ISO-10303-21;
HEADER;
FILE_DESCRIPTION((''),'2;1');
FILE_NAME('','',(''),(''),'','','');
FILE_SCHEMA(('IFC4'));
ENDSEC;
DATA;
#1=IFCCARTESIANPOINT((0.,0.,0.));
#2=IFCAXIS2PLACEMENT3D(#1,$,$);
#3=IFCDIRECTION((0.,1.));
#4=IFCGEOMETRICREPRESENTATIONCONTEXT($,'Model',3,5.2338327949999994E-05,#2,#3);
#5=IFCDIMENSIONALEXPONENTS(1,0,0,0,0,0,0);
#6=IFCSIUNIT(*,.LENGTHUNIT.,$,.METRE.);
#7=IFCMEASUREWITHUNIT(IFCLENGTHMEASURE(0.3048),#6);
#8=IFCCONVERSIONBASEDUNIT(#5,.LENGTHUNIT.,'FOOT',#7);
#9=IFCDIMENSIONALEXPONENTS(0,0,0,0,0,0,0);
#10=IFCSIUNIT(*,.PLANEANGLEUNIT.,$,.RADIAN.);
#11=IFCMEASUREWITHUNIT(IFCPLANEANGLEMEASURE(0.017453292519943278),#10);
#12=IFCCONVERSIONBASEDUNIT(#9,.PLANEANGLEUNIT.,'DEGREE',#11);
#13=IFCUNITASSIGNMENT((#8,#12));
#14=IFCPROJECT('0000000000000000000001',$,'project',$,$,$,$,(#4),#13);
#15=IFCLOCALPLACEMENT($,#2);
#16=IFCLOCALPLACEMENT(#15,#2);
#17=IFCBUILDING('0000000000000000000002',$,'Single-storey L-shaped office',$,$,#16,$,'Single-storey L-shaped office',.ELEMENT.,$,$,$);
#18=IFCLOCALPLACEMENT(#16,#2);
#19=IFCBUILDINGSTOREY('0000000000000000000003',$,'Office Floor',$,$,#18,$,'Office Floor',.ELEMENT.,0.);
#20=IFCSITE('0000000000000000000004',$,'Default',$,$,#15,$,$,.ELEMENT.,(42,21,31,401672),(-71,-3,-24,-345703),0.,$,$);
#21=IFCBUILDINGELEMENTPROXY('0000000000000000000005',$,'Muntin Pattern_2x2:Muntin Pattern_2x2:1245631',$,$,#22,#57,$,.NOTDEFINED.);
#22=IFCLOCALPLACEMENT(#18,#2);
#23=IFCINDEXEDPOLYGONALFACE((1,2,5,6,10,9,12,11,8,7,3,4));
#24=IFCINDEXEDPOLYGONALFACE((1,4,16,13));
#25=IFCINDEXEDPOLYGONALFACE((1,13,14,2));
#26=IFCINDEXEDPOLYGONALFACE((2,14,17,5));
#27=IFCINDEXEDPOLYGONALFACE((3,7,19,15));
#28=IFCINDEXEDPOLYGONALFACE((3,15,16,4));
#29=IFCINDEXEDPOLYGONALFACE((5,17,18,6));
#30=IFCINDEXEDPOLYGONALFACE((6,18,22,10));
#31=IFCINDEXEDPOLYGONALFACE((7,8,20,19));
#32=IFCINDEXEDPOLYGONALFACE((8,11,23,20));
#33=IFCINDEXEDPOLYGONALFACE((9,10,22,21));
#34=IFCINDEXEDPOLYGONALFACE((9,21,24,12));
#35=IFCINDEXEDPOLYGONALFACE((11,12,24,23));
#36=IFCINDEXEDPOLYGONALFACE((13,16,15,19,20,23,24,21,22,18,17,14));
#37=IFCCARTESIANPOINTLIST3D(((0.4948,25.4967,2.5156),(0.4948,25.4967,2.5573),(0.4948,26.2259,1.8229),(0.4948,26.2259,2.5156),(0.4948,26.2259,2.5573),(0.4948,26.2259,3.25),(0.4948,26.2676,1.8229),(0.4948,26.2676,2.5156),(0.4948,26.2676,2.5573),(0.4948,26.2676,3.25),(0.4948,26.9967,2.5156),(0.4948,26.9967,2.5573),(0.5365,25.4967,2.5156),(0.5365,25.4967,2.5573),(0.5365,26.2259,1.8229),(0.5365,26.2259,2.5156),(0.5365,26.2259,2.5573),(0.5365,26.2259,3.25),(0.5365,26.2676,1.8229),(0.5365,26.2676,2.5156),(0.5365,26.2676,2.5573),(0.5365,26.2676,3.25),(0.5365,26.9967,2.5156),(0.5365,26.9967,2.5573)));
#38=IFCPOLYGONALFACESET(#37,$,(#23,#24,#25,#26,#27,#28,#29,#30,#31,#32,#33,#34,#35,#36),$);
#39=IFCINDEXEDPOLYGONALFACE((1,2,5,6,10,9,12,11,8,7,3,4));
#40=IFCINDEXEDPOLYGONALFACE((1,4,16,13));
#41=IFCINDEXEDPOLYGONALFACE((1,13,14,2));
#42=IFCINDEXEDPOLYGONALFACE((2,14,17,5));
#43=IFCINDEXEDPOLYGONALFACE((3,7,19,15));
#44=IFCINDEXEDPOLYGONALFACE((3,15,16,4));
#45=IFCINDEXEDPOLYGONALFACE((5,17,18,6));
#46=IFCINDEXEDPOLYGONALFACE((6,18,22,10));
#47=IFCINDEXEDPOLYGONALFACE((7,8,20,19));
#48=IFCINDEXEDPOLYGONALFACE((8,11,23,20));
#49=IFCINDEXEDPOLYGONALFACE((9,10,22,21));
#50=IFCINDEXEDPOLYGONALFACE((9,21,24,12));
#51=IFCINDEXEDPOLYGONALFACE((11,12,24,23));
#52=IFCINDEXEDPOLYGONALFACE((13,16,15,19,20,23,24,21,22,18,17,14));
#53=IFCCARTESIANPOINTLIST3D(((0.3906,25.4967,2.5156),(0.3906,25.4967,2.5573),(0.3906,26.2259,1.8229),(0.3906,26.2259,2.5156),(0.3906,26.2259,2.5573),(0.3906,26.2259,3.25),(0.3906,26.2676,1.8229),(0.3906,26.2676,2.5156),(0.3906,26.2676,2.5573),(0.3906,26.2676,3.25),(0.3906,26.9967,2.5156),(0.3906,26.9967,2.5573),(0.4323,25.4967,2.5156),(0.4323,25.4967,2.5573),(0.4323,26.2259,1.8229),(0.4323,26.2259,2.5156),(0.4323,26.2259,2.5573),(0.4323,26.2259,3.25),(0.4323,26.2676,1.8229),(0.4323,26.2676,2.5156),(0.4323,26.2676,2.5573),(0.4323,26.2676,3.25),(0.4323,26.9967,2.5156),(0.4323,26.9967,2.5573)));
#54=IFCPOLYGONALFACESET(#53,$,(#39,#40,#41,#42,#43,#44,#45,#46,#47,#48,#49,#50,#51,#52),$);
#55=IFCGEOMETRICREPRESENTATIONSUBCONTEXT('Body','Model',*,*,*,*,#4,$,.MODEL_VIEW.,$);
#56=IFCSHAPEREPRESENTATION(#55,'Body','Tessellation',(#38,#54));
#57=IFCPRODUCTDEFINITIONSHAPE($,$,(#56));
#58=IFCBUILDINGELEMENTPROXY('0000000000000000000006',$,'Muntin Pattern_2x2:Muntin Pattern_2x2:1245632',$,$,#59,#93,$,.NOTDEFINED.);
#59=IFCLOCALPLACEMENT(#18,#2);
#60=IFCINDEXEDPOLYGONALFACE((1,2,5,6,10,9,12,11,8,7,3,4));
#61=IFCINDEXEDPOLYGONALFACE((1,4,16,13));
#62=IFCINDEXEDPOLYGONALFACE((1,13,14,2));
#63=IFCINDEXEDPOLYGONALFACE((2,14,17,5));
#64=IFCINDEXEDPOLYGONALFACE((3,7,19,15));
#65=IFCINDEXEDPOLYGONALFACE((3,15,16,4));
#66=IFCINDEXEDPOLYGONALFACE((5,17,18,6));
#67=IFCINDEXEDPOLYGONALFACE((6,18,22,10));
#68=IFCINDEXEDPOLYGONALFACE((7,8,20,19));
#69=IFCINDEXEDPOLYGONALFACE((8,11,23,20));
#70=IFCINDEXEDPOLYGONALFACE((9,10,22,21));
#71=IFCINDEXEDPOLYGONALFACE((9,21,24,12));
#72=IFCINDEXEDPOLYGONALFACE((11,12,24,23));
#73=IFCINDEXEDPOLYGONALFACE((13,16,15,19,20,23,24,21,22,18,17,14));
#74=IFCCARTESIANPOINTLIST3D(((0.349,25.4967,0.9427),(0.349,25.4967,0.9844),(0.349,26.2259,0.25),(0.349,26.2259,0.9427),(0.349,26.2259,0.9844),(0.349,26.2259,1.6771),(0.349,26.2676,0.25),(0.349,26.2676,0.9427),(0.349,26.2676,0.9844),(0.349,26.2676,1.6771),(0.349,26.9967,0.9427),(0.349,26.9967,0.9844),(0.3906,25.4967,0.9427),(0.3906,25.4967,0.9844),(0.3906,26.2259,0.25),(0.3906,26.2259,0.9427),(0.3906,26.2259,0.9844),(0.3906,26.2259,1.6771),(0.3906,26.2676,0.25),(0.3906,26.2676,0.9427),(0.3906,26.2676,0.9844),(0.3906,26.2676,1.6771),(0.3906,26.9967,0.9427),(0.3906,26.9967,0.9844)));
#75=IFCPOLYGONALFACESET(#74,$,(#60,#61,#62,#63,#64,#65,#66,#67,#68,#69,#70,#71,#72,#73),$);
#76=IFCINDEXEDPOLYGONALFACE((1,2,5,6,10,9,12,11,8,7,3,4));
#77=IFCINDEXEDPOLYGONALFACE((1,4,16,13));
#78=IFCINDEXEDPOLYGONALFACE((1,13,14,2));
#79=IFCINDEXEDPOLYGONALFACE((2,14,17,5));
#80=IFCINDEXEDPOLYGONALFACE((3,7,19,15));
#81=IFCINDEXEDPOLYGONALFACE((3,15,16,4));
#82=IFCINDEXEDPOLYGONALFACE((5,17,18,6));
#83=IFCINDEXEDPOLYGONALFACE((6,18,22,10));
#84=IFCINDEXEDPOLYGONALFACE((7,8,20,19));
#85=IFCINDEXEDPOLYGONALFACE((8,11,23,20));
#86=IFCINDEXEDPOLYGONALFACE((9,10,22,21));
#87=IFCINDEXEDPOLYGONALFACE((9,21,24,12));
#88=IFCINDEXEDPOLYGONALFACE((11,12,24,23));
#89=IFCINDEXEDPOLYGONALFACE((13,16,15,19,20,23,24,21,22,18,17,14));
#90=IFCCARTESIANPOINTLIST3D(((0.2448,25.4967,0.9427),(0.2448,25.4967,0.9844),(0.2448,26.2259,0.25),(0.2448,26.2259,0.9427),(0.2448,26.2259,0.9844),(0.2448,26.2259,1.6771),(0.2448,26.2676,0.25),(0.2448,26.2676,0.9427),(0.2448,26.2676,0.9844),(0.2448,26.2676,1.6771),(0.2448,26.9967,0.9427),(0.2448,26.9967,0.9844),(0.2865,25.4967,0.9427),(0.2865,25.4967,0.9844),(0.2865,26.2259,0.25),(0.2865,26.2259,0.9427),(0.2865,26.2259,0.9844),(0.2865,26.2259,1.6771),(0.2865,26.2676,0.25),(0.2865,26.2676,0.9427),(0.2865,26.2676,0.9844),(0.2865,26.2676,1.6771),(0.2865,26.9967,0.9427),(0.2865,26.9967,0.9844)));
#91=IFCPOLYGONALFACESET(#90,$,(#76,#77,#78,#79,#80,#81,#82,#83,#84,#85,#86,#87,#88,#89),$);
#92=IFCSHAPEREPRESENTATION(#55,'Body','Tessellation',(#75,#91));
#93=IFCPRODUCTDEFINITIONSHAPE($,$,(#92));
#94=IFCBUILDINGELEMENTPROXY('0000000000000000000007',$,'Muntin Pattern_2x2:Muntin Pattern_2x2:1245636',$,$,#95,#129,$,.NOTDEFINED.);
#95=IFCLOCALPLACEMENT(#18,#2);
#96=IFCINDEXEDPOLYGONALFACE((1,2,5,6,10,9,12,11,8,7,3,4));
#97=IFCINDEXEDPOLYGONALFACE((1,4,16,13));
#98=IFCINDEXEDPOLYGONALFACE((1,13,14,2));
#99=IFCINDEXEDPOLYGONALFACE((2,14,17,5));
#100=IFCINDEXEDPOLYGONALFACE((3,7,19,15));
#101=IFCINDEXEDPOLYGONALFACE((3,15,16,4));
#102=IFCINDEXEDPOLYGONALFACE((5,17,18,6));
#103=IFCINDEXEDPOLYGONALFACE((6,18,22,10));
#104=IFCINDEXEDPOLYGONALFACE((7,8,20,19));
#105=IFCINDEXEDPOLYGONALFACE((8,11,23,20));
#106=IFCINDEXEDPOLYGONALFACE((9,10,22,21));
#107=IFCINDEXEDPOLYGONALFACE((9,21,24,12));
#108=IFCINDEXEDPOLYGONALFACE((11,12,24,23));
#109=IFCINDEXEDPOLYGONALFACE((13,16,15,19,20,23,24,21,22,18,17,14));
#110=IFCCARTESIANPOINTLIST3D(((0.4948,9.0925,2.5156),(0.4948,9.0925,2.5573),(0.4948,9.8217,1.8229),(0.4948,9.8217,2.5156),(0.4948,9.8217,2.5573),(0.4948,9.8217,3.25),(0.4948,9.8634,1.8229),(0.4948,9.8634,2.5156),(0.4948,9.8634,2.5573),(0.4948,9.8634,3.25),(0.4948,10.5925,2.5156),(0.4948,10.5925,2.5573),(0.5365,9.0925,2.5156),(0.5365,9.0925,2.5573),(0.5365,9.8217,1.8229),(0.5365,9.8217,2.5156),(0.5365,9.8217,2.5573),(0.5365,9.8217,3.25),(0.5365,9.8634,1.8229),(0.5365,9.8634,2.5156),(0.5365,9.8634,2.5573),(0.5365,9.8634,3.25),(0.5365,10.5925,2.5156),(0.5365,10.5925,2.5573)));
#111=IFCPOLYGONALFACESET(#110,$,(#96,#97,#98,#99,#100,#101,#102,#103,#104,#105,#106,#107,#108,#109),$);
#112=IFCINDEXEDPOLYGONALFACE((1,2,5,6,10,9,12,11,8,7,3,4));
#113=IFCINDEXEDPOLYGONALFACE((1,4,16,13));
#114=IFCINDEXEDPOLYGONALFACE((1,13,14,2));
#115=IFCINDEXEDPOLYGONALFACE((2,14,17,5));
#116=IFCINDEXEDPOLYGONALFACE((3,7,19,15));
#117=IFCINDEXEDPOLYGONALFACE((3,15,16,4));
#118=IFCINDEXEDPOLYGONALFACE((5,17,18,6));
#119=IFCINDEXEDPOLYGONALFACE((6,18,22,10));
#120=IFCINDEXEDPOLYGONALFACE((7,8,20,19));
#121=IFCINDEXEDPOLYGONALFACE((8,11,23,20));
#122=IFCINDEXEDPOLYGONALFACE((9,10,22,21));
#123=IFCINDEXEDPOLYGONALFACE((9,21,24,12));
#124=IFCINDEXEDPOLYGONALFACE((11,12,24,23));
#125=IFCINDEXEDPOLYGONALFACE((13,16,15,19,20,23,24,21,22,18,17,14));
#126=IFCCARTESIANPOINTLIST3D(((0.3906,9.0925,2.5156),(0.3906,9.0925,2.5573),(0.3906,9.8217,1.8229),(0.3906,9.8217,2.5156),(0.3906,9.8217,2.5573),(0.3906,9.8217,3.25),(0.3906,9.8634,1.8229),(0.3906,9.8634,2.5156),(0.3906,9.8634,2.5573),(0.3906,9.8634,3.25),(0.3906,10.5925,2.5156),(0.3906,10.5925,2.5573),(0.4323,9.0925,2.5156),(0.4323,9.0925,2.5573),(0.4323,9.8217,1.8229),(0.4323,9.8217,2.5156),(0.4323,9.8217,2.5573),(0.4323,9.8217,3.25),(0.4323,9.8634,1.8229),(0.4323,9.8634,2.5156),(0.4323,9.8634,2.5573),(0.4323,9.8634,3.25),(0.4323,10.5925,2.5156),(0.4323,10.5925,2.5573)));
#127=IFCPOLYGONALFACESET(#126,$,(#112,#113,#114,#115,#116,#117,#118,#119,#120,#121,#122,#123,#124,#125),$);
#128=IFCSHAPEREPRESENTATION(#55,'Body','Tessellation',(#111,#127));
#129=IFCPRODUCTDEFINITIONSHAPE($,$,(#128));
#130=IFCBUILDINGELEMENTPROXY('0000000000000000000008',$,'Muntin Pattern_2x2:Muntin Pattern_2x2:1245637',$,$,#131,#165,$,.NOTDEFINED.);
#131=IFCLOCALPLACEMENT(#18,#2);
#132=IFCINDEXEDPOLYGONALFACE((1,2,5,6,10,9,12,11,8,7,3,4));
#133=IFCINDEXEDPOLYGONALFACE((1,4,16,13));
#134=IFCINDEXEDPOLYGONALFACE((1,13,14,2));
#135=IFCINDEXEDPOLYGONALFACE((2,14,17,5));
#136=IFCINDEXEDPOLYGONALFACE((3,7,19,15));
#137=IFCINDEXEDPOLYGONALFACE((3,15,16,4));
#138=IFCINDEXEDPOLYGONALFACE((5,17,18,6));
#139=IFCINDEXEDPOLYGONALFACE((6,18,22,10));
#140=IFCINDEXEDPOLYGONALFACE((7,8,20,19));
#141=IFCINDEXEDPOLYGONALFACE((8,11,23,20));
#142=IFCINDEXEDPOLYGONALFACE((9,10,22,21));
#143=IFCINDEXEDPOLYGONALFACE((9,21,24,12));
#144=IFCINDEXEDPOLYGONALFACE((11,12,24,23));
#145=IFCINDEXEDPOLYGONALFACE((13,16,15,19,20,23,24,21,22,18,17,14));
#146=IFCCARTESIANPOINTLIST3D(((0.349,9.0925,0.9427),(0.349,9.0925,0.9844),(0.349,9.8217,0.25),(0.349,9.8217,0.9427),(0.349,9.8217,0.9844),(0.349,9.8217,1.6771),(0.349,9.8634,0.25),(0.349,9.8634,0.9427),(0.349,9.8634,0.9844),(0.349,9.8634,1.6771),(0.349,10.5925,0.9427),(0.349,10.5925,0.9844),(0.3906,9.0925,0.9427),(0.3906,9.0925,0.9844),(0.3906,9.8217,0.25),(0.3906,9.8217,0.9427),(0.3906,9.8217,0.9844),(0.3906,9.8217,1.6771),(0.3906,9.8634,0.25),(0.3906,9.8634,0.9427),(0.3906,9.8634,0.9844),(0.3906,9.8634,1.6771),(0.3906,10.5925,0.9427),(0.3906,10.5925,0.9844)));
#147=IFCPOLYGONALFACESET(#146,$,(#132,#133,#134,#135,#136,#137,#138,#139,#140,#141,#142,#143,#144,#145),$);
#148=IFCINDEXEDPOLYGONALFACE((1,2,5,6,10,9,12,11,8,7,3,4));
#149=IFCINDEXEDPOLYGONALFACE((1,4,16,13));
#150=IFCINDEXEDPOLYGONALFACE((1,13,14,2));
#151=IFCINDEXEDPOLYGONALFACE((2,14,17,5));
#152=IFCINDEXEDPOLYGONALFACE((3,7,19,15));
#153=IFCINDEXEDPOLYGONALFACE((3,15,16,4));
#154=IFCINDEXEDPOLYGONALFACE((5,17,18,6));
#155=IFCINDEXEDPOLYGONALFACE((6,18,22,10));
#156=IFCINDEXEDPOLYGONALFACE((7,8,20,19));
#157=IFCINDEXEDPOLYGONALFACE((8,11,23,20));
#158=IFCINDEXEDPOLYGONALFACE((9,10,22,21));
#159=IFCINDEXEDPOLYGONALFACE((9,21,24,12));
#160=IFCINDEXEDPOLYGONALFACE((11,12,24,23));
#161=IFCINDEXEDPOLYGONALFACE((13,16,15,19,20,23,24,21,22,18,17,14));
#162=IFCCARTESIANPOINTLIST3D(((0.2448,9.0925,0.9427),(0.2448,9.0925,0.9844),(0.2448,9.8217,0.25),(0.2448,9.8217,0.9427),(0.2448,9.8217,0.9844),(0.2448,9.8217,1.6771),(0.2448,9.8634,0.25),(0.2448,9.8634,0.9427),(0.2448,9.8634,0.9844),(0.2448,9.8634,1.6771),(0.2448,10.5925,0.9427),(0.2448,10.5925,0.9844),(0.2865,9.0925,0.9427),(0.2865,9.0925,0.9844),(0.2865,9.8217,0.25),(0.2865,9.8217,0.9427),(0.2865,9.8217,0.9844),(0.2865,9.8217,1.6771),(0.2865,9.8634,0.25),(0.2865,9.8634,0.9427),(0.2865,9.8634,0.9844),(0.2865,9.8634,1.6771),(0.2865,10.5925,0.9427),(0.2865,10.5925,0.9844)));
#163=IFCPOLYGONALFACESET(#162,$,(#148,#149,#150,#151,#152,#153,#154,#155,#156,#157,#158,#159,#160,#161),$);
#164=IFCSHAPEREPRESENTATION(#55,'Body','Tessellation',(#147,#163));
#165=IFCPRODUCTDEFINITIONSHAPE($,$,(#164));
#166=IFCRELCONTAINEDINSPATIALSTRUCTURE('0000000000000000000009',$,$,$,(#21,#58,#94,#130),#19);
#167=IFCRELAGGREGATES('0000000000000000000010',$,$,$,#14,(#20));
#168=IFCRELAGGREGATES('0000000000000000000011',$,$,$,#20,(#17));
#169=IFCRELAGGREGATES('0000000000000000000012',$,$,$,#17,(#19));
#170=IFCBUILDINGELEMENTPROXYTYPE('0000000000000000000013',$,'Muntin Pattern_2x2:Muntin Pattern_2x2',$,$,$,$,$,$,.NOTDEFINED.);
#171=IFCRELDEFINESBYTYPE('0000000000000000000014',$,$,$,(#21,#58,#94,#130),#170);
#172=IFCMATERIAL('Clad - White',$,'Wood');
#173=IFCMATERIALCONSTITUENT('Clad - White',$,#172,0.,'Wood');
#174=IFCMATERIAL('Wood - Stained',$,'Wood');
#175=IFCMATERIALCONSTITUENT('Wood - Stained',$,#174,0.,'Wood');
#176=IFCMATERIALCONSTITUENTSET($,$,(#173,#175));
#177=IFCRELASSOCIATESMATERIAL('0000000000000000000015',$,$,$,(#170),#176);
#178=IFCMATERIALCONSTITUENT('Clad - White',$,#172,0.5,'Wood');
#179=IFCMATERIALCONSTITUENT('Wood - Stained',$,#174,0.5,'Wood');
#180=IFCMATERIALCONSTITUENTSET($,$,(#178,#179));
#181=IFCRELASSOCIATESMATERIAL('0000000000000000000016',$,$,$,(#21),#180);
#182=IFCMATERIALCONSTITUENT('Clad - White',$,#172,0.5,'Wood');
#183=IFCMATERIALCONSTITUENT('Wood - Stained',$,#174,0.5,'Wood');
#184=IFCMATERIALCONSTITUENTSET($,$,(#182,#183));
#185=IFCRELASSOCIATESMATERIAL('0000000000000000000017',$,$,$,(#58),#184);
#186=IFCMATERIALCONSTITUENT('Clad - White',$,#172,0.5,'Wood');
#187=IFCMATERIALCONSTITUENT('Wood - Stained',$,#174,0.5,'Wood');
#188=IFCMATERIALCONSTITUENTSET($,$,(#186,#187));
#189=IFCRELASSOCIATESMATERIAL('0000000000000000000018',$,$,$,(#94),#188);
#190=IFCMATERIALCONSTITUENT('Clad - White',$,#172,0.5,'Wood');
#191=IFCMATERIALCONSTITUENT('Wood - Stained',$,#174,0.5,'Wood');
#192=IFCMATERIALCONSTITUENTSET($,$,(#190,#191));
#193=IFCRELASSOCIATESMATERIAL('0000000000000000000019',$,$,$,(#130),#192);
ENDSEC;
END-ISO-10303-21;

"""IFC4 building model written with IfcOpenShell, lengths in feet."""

from ifc_helpers import new_model, entity, si_unit, converted_unit, direction, frame, origin, place, context, subcontext, project, spatial, indexed_curve, outline, extrude, source, transform, mapped, material, constituent, constituent_set, type_object, type_shapes, element, save


model = new_model("IFC4")

# Units and contexts
model_context = context("Model", 3, precision=5.2338327949999994e-05, world=origin(), true_north=direction((0.0, 1.0)))
body_context = subcontext(model_context, "Body", "Model", "MODEL_VIEW")
ifc_project = project(units=[converted_unit("LENGTHUNIT", "FOOT", entity("IfcLengthMeasure", 0.3048), si_unit("LENGTHUNIT", "METRE"), dimensions=[1, 0, 0, 0, 0, 0, 0]), converted_unit("PLANEANGLEUNIT", "DEGREE", entity("IfcPlaneAngleMeasure", 0.017453292519943278), si_unit("PLANEANGLEUNIT", "RADIAN"), dimensions=[0, 0, 0, 0, 0, 0, 0])], contexts=[model_context])

# Site, building, storey
site_placement = place(None, origin())
site = spatial("IfcSite", under=ifc_project, at=site_placement, Name="Default", CompositionType="ELEMENT", RefLatitude=(42, 21, 31, 401672), RefLongitude=(-71, -3, -24, -345703), RefElevation=0.0)
building_placement = place(site_placement, origin())
building = spatial("IfcBuilding", under=site, at=building_placement, Name="Single-storey L-shaped office", LongName="Single-storey L-shaped office", CompositionType="ELEMENT")
storey_placement = place(building_placement, origin())
storey = spatial("IfcBuildingStorey", under=building, at=storey_placement, Name="Office Floor", LongName="Office Floor", CompositionType="ELEMENT", Elevation=0.0)

# Shared definitions
ifc_material_1 = material(Name="Wood - Stained", Category="Wood")

# Building element proxies
ifc_material_2 = material(Name="Clad - White", Category="Wood")
ifc_constituent_1 = constituent(ifc_material_2, Name="Clad - White", Category="Wood", fraction=0.0)
ifc_constituent_2 = constituent(ifc_material_1, Name="Wood - Stained", Category="Wood", fraction=0.0)
ifc_constituent_set_1 = constituent_set(constituents=[ifc_constituent_1, ifc_constituent_2])
building_element_proxy_type_1 = type_object("IfcBuildingElementProxyType", Name="Muntin Pattern_2x2:Muntin Pattern_2x2", PredefinedType="NOTDEFINED", material=ifc_constituent_set_1)
shared_shape_1 = source(origin(), body_context, "Body", "SweptSolid", [
    extrude(outline(indexed_curve([(0.0208, -0.0208), (0.7135, -0.0208), (0.7135, 0.0208), (0.0208, 0.0208), (0.0208, 0.75), (-0.0208, 0.75), (-0.0208, 0.0208), (-0.7135, 0.0208), (-0.7135, -0.0208), (-0.0208, -0.0208), (-0.0208, -0.75), (0.0208, -0.75), (0.0208, -0.0208)], self_intersect=False)), frame((0.0, 0.0312, 0.7135), z_axis=(0.0, 1.0, 0.0), x_axis=(0.0, 0.0, 1.0)), (0.0, 0.0, 1.0), 0.0417),
    extrude(outline(indexed_curve([(0.0208, -0.0208), (0.7135, -0.0208), (0.7135, 0.0208), (0.0208, 0.0208), (0.0208, 0.75), (-0.0208, 0.75), (-0.0208, 0.0208), (-0.7135, 0.0208), (-0.7135, -0.0208), (-0.0208, -0.0208), (-0.0208, -0.75), (0.0208, -0.75), (0.0208, -0.0208)], self_intersect=False)), frame((0.0, -0.0729, 0.7135), z_axis=(0.0, 1.0, 0.0), x_axis=(0.0, 0.0, 1.0)), (0.0, 0.0, 1.0), 0.0417),
])
type_shapes(building_element_proxy_type_1, [shared_shape_1])
ifc_constituent_3 = constituent(ifc_material_2, Name="Clad - White", Category="Wood", fraction=0.5)
ifc_constituent_4 = constituent(ifc_material_1, Name="Wood - Stained", Category="Wood", fraction=0.5)
ifc_constituent_set_2 = constituent_set(constituents=[ifc_constituent_3, ifc_constituent_4])
proxy_1_placement = place(storey_placement, frame((0.4635, 26.2467, 1.8229), z_axis=(0.0, 0.0, 1.0), x_axis=(0.0, -1.0, 0.0)))
element("IfcBuildingElementProxy", 1, at=proxy_1_placement, inside=storey, type_object=building_element_proxy_type_1, material=ifc_constituent_set_2, Name="Muntin Pattern_2x2:Muntin Pattern_2x2:1245631", PredefinedType="NOTDEFINED", context=body_context, shape_type="MappedRepresentation", body=[
    mapped(shared_shape_1, transform((0.0, 0.0, 0.0), scale=1.0)),
])
ifc_constituent_5 = constituent(ifc_material_2, Name="Clad - White", Category="Wood", fraction=0.5)
ifc_constituent_6 = constituent(ifc_material_1, Name="Wood - Stained", Category="Wood", fraction=0.5)
ifc_constituent_set_3 = constituent_set(constituents=[ifc_constituent_5, ifc_constituent_6])
proxy_2_placement = place(storey_placement, frame((0.3177, 26.2467, 0.25), z_axis=(0.0, 0.0, 1.0), x_axis=(0.0, -1.0, 0.0)))
element("IfcBuildingElementProxy", 2, at=proxy_2_placement, inside=storey, type_object=building_element_proxy_type_1, material=ifc_constituent_set_3, Name="Muntin Pattern_2x2:Muntin Pattern_2x2:1245632", PredefinedType="NOTDEFINED", context=body_context, shape_type="MappedRepresentation", body=[
    mapped(shared_shape_1, transform((0.0, 0.0, 0.0), scale=1.0)),
])
ifc_constituent_7 = constituent(ifc_material_2, Name="Clad - White", Category="Wood", fraction=0.5)
ifc_constituent_8 = constituent(ifc_material_1, Name="Wood - Stained", Category="Wood", fraction=0.5)
ifc_constituent_set_4 = constituent_set(constituents=[ifc_constituent_7, ifc_constituent_8])
proxy_3_placement = place(storey_placement, frame((0.4635, 9.8425, 1.8229), z_axis=(0.0, 0.0, 1.0), x_axis=(0.0, -1.0, 0.0)))
element("IfcBuildingElementProxy", 3, at=proxy_3_placement, inside=storey, type_object=building_element_proxy_type_1, material=ifc_constituent_set_4, Name="Muntin Pattern_2x2:Muntin Pattern_2x2:1245636", PredefinedType="NOTDEFINED", context=body_context, shape_type="MappedRepresentation", body=[
    mapped(shared_shape_1, transform((0.0, 0.0, 0.0), scale=1.0)),
])
ifc_constituent_9 = constituent(ifc_material_2, Name="Clad - White", Category="Wood", fraction=0.5)
ifc_constituent_10 = constituent(ifc_material_1, Name="Wood - Stained", Category="Wood", fraction=0.5)
ifc_constituent_set_5 = constituent_set(constituents=[ifc_constituent_9, ifc_constituent_10])
proxy_4_placement = place(storey_placement, frame((0.3177, 9.8425, 0.25), z_axis=(0.0, 0.0, 1.0), x_axis=(0.0, -1.0, 0.0)))
element("IfcBuildingElementProxy", 4, at=proxy_4_placement, inside=storey, type_object=building_element_proxy_type_1, material=ifc_constituent_set_5, Name="Muntin Pattern_2x2:Muntin Pattern_2x2:1245637", PredefinedType="NOTDEFINED", context=body_context, shape_type="MappedRepresentation", body=[
    mapped(shared_shape_1, transform((0.0, 0.0, 0.0), scale=1.0)),
])

save(model, "model.ifc")
